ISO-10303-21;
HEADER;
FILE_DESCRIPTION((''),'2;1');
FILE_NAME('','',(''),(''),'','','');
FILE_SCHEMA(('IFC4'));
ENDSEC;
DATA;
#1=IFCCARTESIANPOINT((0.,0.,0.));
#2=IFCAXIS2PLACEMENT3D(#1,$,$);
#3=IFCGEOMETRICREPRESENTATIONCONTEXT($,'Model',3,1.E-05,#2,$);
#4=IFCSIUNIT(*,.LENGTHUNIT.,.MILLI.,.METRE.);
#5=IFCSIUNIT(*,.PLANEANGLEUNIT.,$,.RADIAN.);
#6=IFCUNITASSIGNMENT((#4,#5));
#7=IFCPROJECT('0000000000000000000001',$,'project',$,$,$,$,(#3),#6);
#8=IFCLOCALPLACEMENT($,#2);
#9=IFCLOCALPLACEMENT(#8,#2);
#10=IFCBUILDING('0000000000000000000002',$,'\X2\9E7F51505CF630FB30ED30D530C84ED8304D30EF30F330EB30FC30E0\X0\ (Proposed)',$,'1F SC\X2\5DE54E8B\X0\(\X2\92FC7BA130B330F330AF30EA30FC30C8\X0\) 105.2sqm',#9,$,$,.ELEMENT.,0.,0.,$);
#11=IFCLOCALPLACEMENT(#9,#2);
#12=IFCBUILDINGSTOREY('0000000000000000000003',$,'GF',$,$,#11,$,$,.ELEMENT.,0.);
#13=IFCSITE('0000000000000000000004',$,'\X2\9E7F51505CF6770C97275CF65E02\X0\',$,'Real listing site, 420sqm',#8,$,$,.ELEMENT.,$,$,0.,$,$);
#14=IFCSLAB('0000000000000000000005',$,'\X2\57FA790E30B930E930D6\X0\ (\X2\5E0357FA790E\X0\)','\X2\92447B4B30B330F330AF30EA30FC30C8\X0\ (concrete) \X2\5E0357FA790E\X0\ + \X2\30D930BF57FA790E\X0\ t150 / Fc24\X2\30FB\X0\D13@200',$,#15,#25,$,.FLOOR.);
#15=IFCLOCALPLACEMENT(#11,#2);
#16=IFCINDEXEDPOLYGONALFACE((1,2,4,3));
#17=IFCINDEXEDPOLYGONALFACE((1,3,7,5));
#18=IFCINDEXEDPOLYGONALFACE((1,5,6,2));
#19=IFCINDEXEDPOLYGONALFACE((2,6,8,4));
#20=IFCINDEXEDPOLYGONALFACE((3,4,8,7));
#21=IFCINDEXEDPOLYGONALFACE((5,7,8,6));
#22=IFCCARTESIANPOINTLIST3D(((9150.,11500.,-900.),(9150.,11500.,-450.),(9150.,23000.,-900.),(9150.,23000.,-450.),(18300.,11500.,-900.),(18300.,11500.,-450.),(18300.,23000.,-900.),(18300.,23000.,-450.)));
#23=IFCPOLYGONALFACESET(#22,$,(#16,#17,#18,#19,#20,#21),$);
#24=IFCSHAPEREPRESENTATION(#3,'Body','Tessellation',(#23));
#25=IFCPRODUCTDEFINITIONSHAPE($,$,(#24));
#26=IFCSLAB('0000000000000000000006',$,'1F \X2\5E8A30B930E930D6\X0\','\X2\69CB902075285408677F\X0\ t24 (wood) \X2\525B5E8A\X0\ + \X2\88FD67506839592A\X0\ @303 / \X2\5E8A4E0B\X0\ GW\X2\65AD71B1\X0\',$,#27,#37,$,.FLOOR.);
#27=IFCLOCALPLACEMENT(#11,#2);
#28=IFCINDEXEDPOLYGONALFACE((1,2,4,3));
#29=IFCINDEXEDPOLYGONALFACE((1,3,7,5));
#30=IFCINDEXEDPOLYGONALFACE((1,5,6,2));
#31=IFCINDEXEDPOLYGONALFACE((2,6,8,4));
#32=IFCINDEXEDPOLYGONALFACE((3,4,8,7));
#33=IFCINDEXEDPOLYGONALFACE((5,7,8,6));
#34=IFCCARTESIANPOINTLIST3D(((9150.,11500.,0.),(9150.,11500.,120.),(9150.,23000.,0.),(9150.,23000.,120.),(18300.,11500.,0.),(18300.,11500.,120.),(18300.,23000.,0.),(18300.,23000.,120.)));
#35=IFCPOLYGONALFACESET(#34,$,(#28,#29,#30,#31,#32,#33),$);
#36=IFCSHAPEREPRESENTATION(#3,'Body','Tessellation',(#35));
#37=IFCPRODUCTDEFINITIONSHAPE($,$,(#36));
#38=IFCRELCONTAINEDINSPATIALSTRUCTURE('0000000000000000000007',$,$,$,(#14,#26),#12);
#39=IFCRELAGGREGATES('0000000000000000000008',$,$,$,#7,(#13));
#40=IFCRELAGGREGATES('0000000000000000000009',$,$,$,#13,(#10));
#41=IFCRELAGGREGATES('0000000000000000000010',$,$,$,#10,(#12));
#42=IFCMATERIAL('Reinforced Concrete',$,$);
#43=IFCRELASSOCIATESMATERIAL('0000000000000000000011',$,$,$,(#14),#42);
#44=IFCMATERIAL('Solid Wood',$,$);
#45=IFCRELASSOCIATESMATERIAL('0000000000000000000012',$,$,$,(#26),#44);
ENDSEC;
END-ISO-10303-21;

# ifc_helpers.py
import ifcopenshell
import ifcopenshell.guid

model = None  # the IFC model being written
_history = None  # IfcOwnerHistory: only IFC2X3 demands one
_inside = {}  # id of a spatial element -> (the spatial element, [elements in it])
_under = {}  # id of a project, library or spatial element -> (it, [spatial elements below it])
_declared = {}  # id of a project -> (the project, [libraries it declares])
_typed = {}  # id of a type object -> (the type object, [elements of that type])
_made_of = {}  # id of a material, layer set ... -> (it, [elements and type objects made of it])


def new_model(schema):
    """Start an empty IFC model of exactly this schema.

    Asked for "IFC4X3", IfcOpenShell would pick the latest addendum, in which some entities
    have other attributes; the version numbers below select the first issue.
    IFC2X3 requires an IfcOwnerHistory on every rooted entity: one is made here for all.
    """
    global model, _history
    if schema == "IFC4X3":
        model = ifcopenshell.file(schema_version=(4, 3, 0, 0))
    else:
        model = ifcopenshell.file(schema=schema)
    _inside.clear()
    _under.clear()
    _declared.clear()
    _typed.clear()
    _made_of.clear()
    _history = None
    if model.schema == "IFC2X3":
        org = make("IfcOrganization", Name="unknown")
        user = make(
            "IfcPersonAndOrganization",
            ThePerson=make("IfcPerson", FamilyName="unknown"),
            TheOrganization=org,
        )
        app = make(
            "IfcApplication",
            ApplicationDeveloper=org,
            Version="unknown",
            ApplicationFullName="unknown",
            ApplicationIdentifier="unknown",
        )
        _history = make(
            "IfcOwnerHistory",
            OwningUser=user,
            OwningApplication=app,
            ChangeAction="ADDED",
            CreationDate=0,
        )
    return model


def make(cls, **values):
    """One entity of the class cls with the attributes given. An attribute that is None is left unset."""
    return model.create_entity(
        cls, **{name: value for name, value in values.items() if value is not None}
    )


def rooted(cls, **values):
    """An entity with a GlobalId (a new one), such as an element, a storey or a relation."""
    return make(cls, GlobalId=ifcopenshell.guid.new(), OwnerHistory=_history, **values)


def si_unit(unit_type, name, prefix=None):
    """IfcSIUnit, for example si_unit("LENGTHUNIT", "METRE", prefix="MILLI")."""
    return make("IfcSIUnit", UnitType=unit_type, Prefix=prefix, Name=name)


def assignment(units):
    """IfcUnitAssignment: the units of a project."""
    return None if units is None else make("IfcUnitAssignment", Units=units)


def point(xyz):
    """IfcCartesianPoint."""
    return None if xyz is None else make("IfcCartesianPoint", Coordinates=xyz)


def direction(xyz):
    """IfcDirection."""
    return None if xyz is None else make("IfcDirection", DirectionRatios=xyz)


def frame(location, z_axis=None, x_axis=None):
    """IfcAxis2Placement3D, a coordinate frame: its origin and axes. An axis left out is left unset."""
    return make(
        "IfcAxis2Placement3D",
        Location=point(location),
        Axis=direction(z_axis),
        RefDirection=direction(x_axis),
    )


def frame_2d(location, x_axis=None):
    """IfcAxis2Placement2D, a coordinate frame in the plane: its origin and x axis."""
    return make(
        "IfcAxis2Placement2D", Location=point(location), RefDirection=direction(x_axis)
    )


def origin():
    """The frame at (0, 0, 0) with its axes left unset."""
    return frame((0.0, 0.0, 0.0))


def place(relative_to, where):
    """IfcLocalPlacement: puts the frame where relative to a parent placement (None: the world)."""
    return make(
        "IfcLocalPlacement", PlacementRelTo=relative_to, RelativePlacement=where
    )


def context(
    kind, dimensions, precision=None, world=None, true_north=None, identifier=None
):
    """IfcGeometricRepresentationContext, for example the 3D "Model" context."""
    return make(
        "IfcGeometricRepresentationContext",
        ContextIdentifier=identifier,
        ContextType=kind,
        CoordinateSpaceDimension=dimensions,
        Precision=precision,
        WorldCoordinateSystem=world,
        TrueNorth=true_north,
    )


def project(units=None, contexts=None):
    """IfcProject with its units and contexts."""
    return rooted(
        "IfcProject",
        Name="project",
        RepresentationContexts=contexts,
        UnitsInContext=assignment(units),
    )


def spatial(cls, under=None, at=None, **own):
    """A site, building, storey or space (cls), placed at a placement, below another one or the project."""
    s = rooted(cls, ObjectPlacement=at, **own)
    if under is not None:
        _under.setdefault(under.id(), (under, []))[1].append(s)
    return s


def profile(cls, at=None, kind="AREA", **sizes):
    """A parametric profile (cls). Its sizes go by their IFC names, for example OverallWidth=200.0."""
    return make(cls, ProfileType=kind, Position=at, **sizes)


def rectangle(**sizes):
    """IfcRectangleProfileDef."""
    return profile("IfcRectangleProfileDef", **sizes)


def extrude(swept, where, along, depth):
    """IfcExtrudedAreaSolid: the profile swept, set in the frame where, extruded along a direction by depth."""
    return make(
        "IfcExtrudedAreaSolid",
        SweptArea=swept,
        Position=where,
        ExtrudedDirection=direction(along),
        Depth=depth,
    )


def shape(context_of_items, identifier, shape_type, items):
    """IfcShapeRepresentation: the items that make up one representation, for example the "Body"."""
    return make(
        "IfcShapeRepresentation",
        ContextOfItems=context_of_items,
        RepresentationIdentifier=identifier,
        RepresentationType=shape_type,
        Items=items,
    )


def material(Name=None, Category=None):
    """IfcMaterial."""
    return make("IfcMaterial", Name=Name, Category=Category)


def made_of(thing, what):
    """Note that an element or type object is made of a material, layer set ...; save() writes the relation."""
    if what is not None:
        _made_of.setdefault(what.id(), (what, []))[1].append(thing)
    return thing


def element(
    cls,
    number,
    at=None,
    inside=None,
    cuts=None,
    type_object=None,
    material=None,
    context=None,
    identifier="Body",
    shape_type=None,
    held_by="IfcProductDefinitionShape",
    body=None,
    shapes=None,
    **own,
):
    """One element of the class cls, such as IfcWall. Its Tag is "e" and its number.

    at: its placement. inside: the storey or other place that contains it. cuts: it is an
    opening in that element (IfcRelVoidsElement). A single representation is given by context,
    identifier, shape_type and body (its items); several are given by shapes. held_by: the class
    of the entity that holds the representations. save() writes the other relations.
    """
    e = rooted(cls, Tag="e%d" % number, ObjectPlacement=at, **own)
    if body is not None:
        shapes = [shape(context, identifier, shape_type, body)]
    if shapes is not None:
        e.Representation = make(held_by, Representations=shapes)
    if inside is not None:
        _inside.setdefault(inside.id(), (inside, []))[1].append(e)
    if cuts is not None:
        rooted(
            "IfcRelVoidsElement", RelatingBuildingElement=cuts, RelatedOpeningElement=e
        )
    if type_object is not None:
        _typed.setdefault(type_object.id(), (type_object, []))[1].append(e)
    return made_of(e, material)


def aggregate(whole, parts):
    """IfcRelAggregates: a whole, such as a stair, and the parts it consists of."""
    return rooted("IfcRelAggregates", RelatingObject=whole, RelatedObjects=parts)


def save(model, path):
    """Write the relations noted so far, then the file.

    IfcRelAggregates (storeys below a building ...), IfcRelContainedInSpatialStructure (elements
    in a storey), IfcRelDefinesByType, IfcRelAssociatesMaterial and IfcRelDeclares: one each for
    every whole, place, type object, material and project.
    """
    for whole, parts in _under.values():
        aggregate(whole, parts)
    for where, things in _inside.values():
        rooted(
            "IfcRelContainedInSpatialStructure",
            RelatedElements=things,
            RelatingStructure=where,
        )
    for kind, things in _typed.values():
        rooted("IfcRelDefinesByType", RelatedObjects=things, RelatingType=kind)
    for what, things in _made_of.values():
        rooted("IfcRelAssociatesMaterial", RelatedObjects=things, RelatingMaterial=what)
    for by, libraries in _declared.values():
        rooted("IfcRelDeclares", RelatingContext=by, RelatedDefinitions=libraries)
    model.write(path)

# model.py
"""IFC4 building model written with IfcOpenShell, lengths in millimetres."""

from ifc_helpers import new_model, si_unit, frame, frame_2d, origin, place, context, project, spatial, rectangle, extrude, material, element, save


model = new_model("IFC4")

# Units and contexts
model_context = context("Model", 3, precision=1e-05, world=origin())
ifc_project = project(units=[si_unit("LENGTHUNIT", "METRE", prefix="MILLI"), si_unit("PLANEANGLEUNIT", "RADIAN")], contexts=[model_context])

# Site, building, storey
site_placement = place(None, origin())
site = spatial("IfcSite", under=ifc_project, at=site_placement, Name="鹿児島県霧島市", ObjectType="Real listing site, 420sqm", CompositionType="ELEMENT", RefElevation=0.0)
building_placement = place(site_placement, origin())
building = spatial("IfcBuilding", under=site, at=building_placement, Name="鹿児島・ロフト付きワンルーム (Proposed)", ObjectType="1F SC工事(鋼管コンクリート) 105.2sqm", CompositionType="ELEMENT", ElevationOfRefHeight=0.0, ElevationOfTerrain=0.0)
storey_placement = place(building_placement, origin())
storey = spatial("IfcBuildingStorey", under=building, at=storey_placement, Name="GF", CompositionType="ELEMENT", Elevation=0.0)

# Shared definitions
ifc_material_1 = material(Name="Solid Wood")

# Slabs
ifc_material_2 = material(Name="Reinforced Concrete")
slab_1_placement = place(storey_placement, frame((4575.0, 5750.0, -450.0)))
element("IfcSlab", 1, at=slab_1_placement, inside=storey, material=ifc_material_2, Name="基礎スラブ (布基礎)", Description="鉄筋コンクリート (concrete) 布基礎 + ベタ基礎 t150 / Fc24・D13@200", PredefinedType="FLOOR", context=model_context, shape_type="SweptSolid", body=[
    extrude(rectangle(XDim=9150.0, YDim=11500.0, at=frame_2d((4575.0, 5750.0))), frame((4575.0, 5750.0, -450.0)), (0.0, 0.0, 1.0), 450.0),
])
slab_2_placement = place(storey_placement, frame((4575.0, 5750.0, 0.0)))
element("IfcSlab", 2, at=slab_2_placement, inside=storey, material=ifc_material_1, Name="1F 床スラブ", Description="構造用合板 t24 (wood) 剛床 + 製材根太 @303 / 床下 GW断熱", PredefinedType="FLOOR", context=model_context, shape_type="SweptSolid", body=[
    extrude(rectangle(XDim=9150.0, YDim=11500.0, at=frame_2d((4575.0, 5750.0))), frame((4575.0, 5750.0, 0.0)), (0.0, 0.0, 1.0), 120.0),
])

save(model, "model.ifc")
